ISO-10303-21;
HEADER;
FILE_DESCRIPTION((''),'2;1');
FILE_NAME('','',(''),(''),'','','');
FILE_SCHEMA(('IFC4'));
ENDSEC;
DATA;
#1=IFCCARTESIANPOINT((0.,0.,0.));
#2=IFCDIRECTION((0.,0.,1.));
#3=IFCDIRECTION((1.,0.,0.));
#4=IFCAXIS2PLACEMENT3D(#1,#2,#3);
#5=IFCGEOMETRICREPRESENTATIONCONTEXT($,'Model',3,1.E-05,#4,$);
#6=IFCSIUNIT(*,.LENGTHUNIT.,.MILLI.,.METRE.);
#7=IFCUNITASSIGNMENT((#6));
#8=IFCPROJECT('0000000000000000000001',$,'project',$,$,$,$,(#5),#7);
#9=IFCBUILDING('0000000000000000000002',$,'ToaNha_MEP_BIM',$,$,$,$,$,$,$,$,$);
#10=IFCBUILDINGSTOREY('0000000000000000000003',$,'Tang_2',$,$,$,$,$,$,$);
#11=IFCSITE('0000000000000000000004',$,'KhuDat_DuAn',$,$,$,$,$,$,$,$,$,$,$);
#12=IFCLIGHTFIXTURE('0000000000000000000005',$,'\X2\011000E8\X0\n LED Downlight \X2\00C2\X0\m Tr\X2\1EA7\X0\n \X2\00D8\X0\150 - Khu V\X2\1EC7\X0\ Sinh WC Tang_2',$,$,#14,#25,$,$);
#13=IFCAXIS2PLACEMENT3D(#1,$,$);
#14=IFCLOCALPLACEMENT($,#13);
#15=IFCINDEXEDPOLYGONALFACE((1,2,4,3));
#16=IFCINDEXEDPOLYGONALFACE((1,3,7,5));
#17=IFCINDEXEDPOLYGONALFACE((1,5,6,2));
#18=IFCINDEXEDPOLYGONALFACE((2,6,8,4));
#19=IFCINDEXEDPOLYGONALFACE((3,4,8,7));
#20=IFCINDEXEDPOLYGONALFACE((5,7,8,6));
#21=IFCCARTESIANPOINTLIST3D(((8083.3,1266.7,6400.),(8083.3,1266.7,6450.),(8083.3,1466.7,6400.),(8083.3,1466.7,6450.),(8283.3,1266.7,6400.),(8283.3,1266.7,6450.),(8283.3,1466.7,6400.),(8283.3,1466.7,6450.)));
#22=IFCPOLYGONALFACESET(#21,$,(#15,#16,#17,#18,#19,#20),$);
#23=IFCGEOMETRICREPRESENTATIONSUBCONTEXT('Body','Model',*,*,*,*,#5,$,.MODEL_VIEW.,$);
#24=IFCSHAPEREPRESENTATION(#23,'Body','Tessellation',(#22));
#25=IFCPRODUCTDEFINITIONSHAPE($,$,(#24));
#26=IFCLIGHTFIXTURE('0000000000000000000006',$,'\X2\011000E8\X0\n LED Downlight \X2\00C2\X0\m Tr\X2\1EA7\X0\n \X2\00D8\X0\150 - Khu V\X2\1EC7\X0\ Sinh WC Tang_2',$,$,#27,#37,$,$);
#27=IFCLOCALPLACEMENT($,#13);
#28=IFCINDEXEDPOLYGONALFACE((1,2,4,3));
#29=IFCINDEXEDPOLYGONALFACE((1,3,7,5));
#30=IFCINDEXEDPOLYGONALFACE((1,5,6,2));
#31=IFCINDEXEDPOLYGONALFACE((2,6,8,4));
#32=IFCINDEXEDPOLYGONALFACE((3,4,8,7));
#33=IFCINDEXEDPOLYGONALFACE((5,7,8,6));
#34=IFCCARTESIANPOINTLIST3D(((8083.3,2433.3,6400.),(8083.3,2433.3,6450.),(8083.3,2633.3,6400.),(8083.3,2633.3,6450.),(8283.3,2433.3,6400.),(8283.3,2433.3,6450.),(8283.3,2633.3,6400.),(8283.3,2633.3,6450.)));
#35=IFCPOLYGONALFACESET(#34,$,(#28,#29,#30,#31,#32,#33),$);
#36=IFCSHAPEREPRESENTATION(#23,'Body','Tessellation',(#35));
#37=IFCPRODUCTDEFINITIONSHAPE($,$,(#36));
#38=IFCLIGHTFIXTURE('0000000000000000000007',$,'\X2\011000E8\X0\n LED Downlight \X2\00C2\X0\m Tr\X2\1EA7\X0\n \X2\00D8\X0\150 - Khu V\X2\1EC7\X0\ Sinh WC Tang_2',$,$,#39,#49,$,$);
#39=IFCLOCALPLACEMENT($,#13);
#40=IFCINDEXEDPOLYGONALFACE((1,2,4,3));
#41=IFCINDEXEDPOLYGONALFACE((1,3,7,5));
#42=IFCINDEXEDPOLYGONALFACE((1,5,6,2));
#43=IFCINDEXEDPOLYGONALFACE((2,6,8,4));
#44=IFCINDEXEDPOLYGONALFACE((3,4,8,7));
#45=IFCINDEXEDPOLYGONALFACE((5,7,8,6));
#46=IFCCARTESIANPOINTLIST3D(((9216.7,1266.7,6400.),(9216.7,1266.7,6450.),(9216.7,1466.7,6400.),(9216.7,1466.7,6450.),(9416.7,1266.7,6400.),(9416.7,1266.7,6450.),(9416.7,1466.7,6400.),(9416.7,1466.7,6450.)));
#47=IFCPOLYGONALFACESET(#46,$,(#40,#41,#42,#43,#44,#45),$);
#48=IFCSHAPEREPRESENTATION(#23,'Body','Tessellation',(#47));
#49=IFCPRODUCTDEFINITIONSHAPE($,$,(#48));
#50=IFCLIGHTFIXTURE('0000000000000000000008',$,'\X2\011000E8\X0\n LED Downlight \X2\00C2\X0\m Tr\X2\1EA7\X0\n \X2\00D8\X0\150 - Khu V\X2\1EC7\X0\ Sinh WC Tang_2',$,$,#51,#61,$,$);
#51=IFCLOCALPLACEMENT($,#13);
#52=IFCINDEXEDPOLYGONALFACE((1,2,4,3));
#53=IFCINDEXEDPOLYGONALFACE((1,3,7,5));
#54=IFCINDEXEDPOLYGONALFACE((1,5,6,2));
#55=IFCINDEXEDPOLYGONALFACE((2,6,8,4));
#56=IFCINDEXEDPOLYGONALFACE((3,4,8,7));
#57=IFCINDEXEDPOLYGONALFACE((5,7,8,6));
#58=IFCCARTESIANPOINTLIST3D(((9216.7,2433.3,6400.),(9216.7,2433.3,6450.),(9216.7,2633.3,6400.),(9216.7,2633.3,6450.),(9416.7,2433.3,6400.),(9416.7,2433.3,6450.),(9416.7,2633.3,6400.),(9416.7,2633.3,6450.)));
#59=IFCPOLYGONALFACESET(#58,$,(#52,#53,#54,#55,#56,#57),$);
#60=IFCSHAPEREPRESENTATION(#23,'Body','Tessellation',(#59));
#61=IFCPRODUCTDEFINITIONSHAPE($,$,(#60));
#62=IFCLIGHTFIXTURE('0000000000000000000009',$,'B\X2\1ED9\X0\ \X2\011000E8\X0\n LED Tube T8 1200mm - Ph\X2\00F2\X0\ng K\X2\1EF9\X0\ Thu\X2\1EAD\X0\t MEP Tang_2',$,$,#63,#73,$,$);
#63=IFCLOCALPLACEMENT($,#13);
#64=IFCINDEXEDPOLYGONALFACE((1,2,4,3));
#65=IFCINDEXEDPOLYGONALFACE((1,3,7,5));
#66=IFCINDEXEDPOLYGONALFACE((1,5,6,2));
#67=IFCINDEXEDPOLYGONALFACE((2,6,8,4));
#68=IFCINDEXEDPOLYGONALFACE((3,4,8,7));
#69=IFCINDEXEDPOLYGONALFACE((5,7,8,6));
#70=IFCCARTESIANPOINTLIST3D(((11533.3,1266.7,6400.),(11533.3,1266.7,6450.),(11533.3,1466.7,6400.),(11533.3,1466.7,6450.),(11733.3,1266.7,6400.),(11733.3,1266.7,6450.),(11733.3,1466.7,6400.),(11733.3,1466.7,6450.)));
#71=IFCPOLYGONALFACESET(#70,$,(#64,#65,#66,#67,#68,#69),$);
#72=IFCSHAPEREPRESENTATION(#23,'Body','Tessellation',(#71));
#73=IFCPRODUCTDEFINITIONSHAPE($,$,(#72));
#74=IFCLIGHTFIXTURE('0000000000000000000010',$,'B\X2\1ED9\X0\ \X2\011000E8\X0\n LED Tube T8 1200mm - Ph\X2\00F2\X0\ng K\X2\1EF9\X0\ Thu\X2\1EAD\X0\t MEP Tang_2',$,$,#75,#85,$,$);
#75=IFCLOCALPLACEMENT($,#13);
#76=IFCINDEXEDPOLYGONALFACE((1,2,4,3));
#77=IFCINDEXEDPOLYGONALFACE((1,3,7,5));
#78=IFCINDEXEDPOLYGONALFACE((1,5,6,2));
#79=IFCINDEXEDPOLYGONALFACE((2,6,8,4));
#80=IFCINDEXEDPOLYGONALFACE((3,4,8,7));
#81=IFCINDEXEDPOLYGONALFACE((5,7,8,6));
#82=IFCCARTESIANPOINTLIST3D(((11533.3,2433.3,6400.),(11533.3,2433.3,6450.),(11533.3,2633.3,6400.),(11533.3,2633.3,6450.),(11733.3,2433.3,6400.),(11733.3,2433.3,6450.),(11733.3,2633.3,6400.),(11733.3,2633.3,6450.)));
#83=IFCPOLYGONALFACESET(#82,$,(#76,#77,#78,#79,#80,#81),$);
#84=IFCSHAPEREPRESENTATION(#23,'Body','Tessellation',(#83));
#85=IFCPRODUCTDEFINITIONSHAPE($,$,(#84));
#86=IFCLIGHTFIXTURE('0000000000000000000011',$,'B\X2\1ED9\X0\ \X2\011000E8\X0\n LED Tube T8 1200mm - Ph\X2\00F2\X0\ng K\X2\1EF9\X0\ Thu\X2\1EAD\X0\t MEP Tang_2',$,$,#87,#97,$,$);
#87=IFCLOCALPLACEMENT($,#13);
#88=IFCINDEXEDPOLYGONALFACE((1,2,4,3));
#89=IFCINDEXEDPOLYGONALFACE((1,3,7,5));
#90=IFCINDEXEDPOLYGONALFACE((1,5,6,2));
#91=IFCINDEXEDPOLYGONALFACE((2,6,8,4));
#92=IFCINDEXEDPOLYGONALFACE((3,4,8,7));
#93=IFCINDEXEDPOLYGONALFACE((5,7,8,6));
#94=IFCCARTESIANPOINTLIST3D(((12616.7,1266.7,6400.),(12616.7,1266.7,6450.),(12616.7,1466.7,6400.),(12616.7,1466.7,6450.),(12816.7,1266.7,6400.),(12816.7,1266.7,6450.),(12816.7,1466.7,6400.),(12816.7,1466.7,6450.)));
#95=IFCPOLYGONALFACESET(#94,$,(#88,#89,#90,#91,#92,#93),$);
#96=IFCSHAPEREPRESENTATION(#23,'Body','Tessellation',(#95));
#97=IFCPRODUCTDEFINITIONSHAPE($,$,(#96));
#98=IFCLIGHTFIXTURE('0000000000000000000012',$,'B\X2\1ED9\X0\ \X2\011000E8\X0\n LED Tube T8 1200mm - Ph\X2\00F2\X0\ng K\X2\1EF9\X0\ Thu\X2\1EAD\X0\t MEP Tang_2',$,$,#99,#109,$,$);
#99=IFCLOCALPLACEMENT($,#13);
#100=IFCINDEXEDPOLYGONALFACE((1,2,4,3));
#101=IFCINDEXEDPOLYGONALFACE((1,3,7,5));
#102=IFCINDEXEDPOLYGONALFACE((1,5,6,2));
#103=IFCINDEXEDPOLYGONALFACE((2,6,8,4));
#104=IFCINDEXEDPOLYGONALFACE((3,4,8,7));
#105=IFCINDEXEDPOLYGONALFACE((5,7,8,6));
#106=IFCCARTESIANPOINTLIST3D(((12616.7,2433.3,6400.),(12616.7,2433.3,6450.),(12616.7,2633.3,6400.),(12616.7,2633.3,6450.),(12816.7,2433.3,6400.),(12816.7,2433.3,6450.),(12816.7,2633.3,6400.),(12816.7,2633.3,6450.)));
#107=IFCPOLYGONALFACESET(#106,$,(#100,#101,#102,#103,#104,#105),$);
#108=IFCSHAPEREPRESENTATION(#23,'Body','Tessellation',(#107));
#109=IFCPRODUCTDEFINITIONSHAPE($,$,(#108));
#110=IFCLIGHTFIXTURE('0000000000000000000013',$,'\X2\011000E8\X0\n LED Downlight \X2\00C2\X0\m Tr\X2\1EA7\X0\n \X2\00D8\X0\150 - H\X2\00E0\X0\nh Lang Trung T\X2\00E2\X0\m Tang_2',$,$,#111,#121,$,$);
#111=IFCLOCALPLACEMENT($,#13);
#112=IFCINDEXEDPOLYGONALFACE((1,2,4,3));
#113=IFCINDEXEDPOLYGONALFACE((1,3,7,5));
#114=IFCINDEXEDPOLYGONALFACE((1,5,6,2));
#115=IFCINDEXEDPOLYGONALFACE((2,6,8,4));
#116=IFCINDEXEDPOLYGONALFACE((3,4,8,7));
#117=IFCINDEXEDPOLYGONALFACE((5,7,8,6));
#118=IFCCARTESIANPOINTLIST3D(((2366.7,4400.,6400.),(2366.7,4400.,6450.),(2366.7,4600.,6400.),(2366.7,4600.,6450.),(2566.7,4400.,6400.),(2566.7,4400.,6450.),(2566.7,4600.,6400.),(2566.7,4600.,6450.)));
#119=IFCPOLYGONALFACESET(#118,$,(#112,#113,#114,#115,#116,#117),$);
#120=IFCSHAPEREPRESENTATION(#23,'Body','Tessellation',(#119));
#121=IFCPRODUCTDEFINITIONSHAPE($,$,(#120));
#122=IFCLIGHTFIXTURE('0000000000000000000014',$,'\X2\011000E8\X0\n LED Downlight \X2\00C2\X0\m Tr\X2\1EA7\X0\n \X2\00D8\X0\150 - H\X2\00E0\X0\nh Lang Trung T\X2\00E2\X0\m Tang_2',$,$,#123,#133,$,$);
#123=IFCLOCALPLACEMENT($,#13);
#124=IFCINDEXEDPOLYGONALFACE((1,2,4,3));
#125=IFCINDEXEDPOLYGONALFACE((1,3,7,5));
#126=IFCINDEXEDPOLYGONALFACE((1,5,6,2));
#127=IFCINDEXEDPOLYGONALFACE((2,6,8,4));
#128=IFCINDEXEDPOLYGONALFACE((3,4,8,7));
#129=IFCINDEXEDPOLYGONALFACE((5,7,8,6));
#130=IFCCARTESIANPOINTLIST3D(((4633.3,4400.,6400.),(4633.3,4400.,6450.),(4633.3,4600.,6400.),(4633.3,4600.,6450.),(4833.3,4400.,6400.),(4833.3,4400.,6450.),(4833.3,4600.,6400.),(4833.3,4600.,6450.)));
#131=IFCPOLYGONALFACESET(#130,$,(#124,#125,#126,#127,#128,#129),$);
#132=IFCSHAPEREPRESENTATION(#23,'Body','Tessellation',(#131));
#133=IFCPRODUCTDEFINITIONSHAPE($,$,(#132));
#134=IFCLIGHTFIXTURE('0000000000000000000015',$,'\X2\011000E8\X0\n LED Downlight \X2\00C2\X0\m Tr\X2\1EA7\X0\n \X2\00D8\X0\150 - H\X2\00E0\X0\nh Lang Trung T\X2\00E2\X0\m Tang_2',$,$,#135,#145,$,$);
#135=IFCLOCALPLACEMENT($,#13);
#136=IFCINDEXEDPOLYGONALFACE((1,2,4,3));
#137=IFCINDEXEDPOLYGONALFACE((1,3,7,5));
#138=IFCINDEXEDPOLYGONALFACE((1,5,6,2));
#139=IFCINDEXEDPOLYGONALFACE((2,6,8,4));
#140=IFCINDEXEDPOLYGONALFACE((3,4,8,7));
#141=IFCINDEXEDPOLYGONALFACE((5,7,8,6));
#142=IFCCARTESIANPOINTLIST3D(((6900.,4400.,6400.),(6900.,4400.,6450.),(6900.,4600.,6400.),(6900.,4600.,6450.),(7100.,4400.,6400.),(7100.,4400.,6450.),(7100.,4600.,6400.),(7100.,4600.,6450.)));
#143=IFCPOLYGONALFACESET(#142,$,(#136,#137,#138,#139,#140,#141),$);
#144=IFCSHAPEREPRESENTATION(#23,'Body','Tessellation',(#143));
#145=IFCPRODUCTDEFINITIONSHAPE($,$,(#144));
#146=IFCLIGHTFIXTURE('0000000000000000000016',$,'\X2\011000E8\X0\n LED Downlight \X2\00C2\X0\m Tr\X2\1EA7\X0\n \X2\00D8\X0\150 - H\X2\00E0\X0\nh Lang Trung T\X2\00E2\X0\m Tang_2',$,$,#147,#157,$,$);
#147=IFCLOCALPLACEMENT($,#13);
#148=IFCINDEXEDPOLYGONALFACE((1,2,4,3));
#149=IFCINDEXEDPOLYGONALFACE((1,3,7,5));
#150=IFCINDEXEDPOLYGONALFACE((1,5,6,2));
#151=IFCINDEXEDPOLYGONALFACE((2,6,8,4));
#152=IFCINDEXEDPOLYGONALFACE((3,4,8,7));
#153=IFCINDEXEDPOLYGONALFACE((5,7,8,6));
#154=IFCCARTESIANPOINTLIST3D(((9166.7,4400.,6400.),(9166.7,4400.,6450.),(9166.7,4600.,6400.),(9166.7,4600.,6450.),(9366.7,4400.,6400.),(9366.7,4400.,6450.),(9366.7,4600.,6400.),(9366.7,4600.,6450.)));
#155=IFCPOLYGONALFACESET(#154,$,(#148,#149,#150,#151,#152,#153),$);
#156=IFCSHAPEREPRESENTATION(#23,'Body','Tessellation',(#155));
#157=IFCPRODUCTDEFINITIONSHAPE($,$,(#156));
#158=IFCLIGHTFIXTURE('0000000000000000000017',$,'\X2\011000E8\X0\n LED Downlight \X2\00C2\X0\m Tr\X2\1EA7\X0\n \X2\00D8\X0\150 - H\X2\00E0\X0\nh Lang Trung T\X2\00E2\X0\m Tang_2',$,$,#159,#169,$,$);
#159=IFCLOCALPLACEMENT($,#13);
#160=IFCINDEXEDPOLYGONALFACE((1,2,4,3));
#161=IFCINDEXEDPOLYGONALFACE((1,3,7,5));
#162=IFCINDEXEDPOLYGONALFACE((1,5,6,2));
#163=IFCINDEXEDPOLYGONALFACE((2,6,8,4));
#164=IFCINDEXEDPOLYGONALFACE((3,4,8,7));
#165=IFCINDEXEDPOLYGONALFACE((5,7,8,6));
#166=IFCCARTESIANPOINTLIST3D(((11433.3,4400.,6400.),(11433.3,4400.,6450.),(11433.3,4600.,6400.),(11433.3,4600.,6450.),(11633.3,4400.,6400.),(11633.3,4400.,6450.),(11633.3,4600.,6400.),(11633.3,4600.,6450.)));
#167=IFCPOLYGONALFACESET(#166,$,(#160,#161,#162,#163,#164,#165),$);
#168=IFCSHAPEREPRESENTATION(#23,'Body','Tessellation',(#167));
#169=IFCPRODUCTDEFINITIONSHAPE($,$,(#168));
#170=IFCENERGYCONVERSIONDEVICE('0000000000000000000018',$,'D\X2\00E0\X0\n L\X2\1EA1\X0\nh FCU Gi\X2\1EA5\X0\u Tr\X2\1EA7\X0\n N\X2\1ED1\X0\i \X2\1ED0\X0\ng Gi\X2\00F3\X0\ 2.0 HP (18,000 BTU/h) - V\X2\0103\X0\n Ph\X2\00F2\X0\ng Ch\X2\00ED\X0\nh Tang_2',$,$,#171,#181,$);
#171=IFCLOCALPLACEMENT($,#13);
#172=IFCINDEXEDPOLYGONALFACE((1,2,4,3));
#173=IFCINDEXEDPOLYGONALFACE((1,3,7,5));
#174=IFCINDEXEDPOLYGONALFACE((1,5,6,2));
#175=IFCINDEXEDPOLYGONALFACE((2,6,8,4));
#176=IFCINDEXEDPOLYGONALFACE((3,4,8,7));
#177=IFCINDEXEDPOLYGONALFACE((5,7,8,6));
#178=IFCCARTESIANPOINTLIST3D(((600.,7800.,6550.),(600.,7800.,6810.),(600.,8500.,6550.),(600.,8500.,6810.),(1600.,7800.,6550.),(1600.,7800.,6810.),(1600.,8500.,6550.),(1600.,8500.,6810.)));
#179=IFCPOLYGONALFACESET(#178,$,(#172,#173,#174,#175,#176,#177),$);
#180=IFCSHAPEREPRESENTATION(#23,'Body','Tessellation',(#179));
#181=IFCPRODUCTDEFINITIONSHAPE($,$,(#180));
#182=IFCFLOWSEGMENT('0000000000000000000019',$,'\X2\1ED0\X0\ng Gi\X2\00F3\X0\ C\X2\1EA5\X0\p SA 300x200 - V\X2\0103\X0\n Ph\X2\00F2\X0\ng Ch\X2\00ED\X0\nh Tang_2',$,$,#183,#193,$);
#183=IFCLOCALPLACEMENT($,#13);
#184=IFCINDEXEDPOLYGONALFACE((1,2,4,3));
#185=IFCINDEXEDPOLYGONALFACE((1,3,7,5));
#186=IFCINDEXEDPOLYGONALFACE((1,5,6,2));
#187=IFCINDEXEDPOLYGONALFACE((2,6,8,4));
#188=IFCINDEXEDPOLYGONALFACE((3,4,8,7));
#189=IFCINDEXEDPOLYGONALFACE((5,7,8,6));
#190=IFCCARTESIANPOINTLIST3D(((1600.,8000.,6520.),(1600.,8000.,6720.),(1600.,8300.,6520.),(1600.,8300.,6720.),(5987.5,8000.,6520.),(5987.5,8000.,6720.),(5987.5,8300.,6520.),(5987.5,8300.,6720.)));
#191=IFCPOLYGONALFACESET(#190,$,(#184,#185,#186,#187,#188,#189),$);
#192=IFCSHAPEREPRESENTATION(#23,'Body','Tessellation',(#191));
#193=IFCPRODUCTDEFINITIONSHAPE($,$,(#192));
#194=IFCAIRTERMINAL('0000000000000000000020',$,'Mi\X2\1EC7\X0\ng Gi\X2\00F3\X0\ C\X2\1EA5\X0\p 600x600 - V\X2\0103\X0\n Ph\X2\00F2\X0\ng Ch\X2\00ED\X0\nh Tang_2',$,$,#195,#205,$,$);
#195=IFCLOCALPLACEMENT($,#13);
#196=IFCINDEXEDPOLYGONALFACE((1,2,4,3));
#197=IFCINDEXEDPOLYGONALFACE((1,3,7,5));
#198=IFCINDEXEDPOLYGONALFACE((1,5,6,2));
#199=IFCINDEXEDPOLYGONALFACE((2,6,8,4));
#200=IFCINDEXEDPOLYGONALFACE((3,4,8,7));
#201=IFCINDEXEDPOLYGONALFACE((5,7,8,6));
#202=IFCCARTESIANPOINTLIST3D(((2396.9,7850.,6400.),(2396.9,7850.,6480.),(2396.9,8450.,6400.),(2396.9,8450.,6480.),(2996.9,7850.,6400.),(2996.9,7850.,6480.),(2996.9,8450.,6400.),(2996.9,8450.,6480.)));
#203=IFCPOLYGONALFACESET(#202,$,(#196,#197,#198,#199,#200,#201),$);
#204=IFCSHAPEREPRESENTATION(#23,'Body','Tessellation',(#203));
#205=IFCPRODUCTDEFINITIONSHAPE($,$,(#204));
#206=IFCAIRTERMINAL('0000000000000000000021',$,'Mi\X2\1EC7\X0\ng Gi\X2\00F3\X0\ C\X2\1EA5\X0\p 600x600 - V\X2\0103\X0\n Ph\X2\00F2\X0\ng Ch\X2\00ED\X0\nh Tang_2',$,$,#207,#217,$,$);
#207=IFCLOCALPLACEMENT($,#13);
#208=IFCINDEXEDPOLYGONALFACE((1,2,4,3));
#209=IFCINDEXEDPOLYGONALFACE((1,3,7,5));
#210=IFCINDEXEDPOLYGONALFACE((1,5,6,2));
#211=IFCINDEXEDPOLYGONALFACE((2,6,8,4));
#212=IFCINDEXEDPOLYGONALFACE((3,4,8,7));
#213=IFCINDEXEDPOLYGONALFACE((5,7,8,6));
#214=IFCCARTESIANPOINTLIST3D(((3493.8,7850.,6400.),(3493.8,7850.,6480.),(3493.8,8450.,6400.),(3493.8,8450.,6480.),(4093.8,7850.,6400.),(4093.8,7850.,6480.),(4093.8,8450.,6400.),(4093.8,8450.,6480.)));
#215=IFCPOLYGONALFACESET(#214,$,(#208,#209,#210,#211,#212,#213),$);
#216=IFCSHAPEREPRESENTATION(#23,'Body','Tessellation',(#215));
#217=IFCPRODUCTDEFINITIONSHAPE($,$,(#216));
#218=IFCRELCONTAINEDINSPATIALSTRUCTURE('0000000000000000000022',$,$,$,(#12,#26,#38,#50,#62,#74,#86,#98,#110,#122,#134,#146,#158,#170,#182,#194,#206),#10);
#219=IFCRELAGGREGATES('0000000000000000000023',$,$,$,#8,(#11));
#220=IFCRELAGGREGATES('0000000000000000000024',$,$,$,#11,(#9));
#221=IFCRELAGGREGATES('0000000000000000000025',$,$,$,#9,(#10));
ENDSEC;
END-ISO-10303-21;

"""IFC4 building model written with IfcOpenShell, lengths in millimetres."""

from ifc_helpers import new_model, si_unit, frame, origin_with_axes, context, subcontext, project, spatial, polyline, outline, extrude, element, save


model = new_model("IFC4")

# Units and contexts
model_context = context("Model", 3, precision=1e-05, world=origin_with_axes())
body_context = subcontext(model_context, "Body", "Model", "MODEL_VIEW")
ifc_project = project(units=[si_unit("LENGTHUNIT", "METRE", prefix="MILLI")], contexts=[model_context])

# Site, building, storey
site = spatial("IfcSite", under=ifc_project, Name="KhuDat_DuAn")
building = spatial("IfcBuilding", under=site, Name="ToaNha_MEP_BIM")
storey = spatial("IfcBuildingStorey", under=building, Name="Tang_2")

# Light fixtures
element("IfcLightFixture", 1, inside=storey, Name="Đèn LED Downlight Âm Trần Ø150 - Khu Vệ Sinh WC Tang_2", context=body_context, shape_type="SweptSolid", body=[
    extrude(outline(polyline([(8083.3, 1266.7), (8283.3, 1266.7), (8283.3, 1466.7), (8083.3, 1466.7), (8083.3, 1266.7)])), frame((0.0, 0.0, 6400.0), z_axis=(0.0, 0.0, 1.0), x_axis=(1.0, 0.0, 0.0)), (0.0, 0.0, 1.0), 50.0),
])
element("IfcLightFixture", 2, inside=storey, Name="Đèn LED Downlight Âm Trần Ø150 - Khu Vệ Sinh WC Tang_2", context=body_context, shape_type="SweptSolid", body=[
    extrude(outline(polyline([(8083.3, 2433.3), (8283.3, 2433.3), (8283.3, 2633.3), (8083.3, 2633.3), (8083.3, 2433.3)])), frame((0.0, 0.0, 6400.0), z_axis=(0.0, 0.0, 1.0), x_axis=(1.0, 0.0, 0.0)), (0.0, 0.0, 1.0), 50.0),
])
element("IfcLightFixture", 3, inside=storey, Name="Đèn LED Downlight Âm Trần Ø150 - Khu Vệ Sinh WC Tang_2", context=body_context, shape_type="SweptSolid", body=[
    extrude(outline(polyline([(9216.7, 1266.7), (9416.7, 1266.7), (9416.7, 1466.7), (9216.7, 1466.7), (9216.7, 1266.7)])), frame((0.0, 0.0, 6400.0), z_axis=(0.0, 0.0, 1.0), x_axis=(1.0, 0.0, 0.0)), (0.0, 0.0, 1.0), 50.0),
])
element("IfcLightFixture", 4, inside=storey, Name="Đèn LED Downlight Âm Trần Ø150 - Khu Vệ Sinh WC Tang_2", context=body_context, shape_type="SweptSolid", body=[
    extrude(outline(polyline([(9216.7, 2433.3), (9416.7, 2433.3), (9416.7, 2633.3), (9216.7, 2633.3), (9216.7, 2433.3)])), frame((0.0, 0.0, 6400.0), z_axis=(0.0, 0.0, 1.0), x_axis=(1.0, 0.0, 0.0)), (0.0, 0.0, 1.0), 50.0),
])
element("IfcLightFixture", 5, inside=storey, Name="Bộ Đèn LED Tube T8 1200mm - Phòng Kỹ Thuật MEP Tang_2", context=body_context, shape_type="SweptSolid", body=[
    extrude(outline(polyline([(11533.3, 1266.7), (11733.3, 1266.7), (11733.3, 1466.7), (11533.3, 1466.7), (11533.3, 1266.7)])), frame((0.0, 0.0, 6400.0), z_axis=(0.0, 0.0, 1.0), x_axis=(1.0, 0.0, 0.0)), (0.0, 0.0, 1.0), 50.0),
])
element("IfcLightFixture", 6, inside=storey, Name="Bộ Đèn LED Tube T8 1200mm - Phòng Kỹ Thuật MEP Tang_2", context=body_context, shape_type="SweptSolid", body=[
    extrude(outline(polyline([(11533.3, 2433.3), (11733.3, 2433.3), (11733.3, 2633.3), (11533.3, 2633.3), (11533.3, 2433.3)])), frame((0.0, 0.0, 6400.0), z_axis=(0.0, 0.0, 1.0), x_axis=(1.0, 0.0, 0.0)), (0.0, 0.0, 1.0), 50.0),
])
element("IfcLightFixture", 7, inside=storey, Name="Bộ Đèn LED Tube T8 1200mm - Phòng Kỹ Thuật MEP Tang_2", context=body_context, shape_type="SweptSolid", body=[
    extrude(outline(polyline([(12616.7, 1266.7), (12816.7, 1266.7), (12816.7, 1466.7), (12616.7, 1466.7), (12616.7, 1266.7)])), frame((0.0, 0.0, 6400.0), z_axis=(0.0, 0.0, 1.0), x_axis=(1.0, 0.0, 0.0)), (0.0, 0.0, 1.0), 50.0),
])
element("IfcLightFixture", 8, inside=storey, Name="Bộ Đèn LED Tube T8 1200mm - Phòng Kỹ Thuật MEP Tang_2", context=body_context, shape_type="SweptSolid", body=[
    extrude(outline(polyline([(12616.7, 2433.3), (12816.7, 2433.3), (12816.7, 2633.3), (12616.7, 2633.3), (12616.7, 2433.3)])), frame((0.0, 0.0, 6400.0), z_axis=(0.0, 0.0, 1.0), x_axis=(1.0, 0.0, 0.0)), (0.0, 0.0, 1.0), 50.0),
])
element("IfcLightFixture", 9, inside=storey, Name="Đèn LED Downlight Âm Trần Ø150 - Hành Lang Trung Tâm Tang_2", context=body_context, shape_type="SweptSolid", body=[
    extrude(outline(polyline([(2366.7, 4400.0), (2566.7, 4400.0), (2566.7, 4600.0), (2366.7, 4600.0), (2366.7, 4400.0)])), frame((0.0, 0.0, 6400.0), z_axis=(0.0, 0.0, 1.0), x_axis=(1.0, 0.0, 0.0)), (0.0, 0.0, 1.0), 50.0),
])
element("IfcLightFixture", 10, inside=storey, Name="Đèn LED Downlight Âm Trần Ø150 - Hành Lang Trung Tâm Tang_2", context=body_context, shape_type="SweptSolid", body=[
    extrude(outline(polyline([(4633.3, 4400.0), (4833.3, 4400.0), (4833.3, 4600.0), (4633.3, 4600.0), (4633.3, 4400.0)])), frame((0.0, 0.0, 6400.0), z_axis=(0.0, 0.0, 1.0), x_axis=(1.0, 0.0, 0.0)), (0.0, 0.0, 1.0), 50.0),
])
element("IfcLightFixture", 11, inside=storey, Name="Đèn LED Downlight Âm Trần Ø150 - Hành Lang Trung Tâm Tang_2", context=body_context, shape_type="SweptSolid", body=[
    extrude(outline(polyline([(6900.0, 4400.0), (7100.0, 4400.0), (7100.0, 4600.0), (6900.0, 4600.0), (6900.0, 4400.0)])), frame((0.0, 0.0, 6400.0), z_axis=(0.0, 0.0, 1.0), x_axis=(1.0, 0.0, 0.0)), (0.0, 0.0, 1.0), 50.0),
])
element("IfcLightFixture", 12, inside=storey, Name="Đèn LED Downlight Âm Trần Ø150 - Hành Lang Trung Tâm Tang_2", context=body_context, shape_type="SweptSolid", body=[
    extrude(outline(polyline([(9166.7, 4400.0), (9366.7, 4400.0), (9366.7, 4600.0), (9166.7, 4600.0), (9166.7, 4400.0)])), frame((0.0, 0.0, 6400.0), z_axis=(0.0, 0.0, 1.0), x_axis=(1.0, 0.0, 0.0)), (0.0, 0.0, 1.0), 50.0),
])
element("IfcLightFixture", 13, inside=storey, Name="Đèn LED Downlight Âm Trần Ø150 - Hành Lang Trung Tâm Tang_2", context=body_context, shape_type="SweptSolid", body=[
    extrude(outline(polyline([(11433.3, 4400.0), (11633.3, 4400.0), (11633.3, 4600.0), (11433.3, 4600.0), (11433.3, 4400.0)])), frame((0.0, 0.0, 6400.0), z_axis=(0.0, 0.0, 1.0), x_axis=(1.0, 0.0, 0.0)), (0.0, 0.0, 1.0), 50.0),
])

# Energy conversion device
element("IfcEnergyConversionDevice", 14, inside=storey, Name="Dàn Lạnh FCU Giấu Trần Nối Ống Gió 2.0 HP (18,000 BTU/h) - Văn Phòng Chính Tang_2", context=body_context, shape_type="SweptSolid", body=[
    extrude(outline(polyline([(600.0, 7800.0), (1600.0, 7800.0), (1600.0, 8500.0), (600.0, 8500.0), (600.0, 7800.0)])), frame((0.0, 0.0, 6550.0), z_axis=(0.0, 0.0, 1.0), x_axis=(1.0, 0.0, 0.0)), (0.0, 0.0, 1.0), 260.0),
])

# Flow segment
element("IfcFlowSegment", 15, inside=storey, Name="Ống Gió Cấp SA 300x200 - Văn Phòng Chính Tang_2", context=body_context, shape_type="SweptSolid", body=[
    extrude(outline(polyline([(1600.0, 8000.0), (5987.5, 8000.0), (5987.5, 8300.0), (1600.0, 8300.0), (1600.0, 8000.0)])), frame((0.0, 0.0, 6520.0), z_axis=(0.0, 0.0, 1.0), x_axis=(1.0, 0.0, 0.0)), (0.0, 0.0, 1.0), 200.0),
])

# Air terminals
element("IfcAirTerminal", 16, inside=storey, Name="Miệng Gió Cấp 600x600 - Văn Phòng Chính Tang_2", context=body_context, shape_type="SweptSolid", body=[
    extrude(outline(polyline([(2396.9, 7850.0), (2996.9, 7850.0), (2996.9, 8450.0), (2396.9, 8450.0), (2396.9, 7850.0)])), frame((0.0, 0.0, 6400.0), z_axis=(0.0, 0.0, 1.0), x_axis=(1.0, 0.0, 0.0)), (0.0, 0.0, 1.0), 80.0),
])
element("IfcAirTerminal", 17, inside=storey, Name="Miệng Gió Cấp 600x600 - Văn Phòng Chính Tang_2", context=body_context, shape_type="SweptSolid", body=[
    extrude(outline(polyline([(3493.8, 7850.0), (4093.8, 7850.0), (4093.8, 8450.0), (3493.8, 8450.0), (3493.8, 7850.0)])), frame((0.0, 0.0, 6400.0), z_axis=(0.0, 0.0, 1.0), x_axis=(1.0, 0.0, 0.0)), (0.0, 0.0, 1.0), 80.0),
])

save(model, "model.ifc")
